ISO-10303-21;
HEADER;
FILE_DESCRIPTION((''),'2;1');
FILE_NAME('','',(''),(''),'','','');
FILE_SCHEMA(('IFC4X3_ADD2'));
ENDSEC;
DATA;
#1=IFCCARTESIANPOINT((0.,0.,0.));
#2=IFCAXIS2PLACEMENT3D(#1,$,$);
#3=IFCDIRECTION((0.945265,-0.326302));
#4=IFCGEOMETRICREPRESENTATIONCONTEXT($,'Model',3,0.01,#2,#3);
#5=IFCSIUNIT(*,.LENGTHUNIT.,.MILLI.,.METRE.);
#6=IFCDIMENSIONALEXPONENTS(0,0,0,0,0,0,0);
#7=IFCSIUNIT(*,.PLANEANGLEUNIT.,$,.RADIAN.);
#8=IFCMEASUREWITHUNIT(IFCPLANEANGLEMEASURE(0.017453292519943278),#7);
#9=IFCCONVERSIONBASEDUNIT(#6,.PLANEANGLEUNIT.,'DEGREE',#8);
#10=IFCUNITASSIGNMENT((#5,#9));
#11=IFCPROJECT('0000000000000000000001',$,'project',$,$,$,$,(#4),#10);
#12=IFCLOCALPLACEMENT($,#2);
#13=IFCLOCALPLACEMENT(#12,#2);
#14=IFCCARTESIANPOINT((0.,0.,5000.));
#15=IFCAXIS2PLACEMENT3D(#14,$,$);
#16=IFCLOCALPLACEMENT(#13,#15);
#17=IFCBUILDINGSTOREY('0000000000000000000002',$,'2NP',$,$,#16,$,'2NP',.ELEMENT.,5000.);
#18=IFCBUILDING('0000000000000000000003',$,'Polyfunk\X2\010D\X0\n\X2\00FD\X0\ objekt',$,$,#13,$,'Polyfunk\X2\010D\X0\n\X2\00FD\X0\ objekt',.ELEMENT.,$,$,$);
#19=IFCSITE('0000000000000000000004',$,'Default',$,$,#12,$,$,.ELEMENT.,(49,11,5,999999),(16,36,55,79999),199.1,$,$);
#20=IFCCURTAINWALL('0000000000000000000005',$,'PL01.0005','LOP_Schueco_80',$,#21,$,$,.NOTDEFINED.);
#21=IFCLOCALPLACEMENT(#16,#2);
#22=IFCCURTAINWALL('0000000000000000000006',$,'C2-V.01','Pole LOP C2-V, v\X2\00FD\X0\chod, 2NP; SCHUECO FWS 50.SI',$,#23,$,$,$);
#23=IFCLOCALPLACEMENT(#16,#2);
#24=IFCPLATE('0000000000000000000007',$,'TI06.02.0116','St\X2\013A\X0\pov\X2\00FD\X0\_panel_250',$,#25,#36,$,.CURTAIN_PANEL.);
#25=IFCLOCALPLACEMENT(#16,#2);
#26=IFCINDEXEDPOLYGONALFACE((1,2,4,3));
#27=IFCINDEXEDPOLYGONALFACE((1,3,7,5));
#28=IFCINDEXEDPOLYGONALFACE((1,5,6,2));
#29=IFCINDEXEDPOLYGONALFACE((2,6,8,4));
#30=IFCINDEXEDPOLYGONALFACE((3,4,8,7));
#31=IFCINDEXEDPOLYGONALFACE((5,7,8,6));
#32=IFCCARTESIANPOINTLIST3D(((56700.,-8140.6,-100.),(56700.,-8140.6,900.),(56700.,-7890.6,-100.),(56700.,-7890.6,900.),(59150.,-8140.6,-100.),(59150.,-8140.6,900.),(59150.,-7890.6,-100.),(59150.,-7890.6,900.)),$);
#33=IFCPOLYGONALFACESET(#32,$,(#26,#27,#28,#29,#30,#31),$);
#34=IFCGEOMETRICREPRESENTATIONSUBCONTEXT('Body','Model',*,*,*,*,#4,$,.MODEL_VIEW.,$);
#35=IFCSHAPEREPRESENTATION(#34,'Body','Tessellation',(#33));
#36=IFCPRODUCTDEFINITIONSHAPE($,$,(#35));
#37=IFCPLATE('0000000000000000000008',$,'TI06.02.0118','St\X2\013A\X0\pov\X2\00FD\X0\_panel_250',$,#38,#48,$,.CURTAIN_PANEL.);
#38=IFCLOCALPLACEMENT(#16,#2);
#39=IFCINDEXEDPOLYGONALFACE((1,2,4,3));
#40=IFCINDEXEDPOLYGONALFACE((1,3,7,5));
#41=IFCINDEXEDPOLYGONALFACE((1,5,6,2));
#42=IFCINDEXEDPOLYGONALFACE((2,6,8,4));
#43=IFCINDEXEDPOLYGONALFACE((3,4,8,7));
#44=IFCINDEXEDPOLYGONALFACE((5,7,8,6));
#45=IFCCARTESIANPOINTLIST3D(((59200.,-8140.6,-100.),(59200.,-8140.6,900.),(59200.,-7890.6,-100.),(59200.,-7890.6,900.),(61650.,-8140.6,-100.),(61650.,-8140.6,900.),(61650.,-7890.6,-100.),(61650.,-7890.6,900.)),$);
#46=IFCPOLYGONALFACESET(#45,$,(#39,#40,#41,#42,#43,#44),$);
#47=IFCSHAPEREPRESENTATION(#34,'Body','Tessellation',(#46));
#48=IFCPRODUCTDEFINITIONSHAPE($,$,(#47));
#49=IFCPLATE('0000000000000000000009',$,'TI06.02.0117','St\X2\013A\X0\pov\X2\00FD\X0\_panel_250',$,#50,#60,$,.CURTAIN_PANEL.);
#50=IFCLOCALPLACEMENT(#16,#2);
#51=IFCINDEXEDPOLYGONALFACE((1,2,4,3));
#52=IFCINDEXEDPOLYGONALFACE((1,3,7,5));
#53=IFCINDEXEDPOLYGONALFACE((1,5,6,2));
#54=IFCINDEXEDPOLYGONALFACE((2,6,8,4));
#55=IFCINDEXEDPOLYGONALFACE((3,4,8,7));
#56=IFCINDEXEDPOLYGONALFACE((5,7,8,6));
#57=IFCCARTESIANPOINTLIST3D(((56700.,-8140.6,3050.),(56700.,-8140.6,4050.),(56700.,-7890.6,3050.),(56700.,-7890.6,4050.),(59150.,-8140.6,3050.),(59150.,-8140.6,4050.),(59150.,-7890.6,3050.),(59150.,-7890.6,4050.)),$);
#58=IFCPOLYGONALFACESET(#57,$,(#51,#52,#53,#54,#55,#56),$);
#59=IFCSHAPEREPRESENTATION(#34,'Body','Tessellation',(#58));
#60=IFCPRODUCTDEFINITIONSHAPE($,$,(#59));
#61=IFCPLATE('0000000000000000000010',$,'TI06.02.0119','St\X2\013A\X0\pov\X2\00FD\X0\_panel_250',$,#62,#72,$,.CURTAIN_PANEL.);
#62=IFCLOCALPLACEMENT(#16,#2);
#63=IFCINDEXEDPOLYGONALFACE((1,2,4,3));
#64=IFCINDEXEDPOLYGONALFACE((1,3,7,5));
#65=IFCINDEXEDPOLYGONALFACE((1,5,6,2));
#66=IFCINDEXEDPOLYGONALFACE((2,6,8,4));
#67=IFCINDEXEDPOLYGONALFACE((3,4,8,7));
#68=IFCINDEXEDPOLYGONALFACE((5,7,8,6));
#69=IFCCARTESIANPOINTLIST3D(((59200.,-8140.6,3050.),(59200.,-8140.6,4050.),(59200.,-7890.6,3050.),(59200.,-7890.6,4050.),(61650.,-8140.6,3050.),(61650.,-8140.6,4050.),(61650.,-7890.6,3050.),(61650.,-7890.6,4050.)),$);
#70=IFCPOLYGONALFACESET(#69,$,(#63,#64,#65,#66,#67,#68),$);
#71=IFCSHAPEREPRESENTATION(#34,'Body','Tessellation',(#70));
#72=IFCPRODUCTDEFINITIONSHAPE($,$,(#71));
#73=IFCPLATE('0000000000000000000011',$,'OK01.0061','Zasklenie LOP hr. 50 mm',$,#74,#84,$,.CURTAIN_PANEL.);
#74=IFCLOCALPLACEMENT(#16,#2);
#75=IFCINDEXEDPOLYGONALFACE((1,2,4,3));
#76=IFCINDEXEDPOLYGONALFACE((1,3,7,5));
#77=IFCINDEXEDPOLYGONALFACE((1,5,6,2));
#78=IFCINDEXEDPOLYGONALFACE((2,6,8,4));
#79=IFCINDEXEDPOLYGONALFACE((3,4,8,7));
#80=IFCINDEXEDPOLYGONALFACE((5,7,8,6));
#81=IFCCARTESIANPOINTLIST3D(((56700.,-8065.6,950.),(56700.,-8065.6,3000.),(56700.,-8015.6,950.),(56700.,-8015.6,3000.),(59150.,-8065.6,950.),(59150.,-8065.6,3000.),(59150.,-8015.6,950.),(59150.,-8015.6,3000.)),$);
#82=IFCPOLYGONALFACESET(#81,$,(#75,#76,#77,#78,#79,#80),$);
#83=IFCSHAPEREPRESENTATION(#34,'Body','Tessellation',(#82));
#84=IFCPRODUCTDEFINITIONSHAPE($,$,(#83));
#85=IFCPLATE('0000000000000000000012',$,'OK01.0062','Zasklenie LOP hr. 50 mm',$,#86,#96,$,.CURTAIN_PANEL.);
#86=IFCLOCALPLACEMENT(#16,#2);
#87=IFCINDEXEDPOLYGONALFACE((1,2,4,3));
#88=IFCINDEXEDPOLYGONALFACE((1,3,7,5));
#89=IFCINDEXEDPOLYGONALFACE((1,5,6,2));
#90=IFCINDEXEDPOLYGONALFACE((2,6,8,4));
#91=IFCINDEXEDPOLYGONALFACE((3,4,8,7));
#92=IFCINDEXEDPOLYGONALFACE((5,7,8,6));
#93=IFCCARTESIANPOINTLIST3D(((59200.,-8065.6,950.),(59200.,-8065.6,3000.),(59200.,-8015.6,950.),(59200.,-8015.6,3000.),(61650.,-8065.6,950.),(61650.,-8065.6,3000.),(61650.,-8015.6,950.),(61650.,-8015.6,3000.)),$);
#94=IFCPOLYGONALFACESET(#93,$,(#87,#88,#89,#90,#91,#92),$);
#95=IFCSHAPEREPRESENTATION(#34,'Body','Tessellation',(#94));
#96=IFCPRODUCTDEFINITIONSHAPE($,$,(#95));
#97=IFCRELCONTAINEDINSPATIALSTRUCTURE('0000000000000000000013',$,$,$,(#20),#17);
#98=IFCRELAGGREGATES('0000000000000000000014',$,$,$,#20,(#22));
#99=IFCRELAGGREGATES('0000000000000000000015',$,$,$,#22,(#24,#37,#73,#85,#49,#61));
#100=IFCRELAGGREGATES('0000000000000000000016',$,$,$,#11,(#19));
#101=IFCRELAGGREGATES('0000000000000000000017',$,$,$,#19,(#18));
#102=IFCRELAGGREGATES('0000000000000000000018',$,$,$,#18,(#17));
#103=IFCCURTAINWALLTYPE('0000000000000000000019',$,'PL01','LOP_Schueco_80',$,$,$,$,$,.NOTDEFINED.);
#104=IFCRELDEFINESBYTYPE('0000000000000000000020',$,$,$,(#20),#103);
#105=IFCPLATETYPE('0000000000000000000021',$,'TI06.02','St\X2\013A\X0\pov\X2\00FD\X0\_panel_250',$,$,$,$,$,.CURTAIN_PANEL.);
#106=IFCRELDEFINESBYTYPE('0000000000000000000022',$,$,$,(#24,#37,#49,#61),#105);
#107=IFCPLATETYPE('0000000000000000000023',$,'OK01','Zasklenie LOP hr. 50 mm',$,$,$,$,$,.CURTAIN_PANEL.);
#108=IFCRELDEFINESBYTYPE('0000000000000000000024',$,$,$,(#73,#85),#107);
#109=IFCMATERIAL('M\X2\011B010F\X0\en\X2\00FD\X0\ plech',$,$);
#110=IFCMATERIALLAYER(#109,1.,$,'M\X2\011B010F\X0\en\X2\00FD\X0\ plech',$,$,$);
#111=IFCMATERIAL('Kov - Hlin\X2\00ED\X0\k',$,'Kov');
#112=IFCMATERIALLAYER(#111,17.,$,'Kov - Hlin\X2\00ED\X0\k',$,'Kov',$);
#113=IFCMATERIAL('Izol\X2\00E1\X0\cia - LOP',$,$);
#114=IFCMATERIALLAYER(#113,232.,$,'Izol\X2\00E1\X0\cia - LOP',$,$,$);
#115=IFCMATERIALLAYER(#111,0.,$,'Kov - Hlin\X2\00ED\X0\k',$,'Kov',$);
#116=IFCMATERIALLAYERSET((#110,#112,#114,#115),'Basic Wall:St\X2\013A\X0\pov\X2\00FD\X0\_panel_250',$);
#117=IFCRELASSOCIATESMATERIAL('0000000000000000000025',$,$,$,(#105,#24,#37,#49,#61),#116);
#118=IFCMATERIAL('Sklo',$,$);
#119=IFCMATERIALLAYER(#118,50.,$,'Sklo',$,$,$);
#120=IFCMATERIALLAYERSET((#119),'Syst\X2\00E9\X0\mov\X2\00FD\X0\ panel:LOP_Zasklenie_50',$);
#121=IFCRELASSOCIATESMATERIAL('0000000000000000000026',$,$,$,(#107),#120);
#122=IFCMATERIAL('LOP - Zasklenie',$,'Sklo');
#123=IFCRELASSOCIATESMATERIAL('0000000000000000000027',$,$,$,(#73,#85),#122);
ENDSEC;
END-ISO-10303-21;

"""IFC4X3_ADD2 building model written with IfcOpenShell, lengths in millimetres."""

from ifc_helpers import new_model, entity, si_unit, converted_unit, direction, frame, frame_2d, origin, origin_2d_with_axis, place, context, subcontext, project, spatial, rectangle, extrude, source, transform, mapped, material, layer, layer_set, layer_usage, type_object, type_shapes, element, aggregate, save


model = new_model("IFC4X3_ADD2")

# Units and contexts
model_context = context("Model", 3, precision=0.01, world=origin(), true_north=direction((0.945265, -0.326302)))
body_context = subcontext(model_context, "Body", "Model", "MODEL_VIEW")
ifc_project = project(units=[si_unit("LENGTHUNIT", "METRE", prefix="MILLI"), converted_unit("PLANEANGLEUNIT", "DEGREE", entity("IfcPlaneAngleMeasure", 0.017453292519943278), si_unit("PLANEANGLEUNIT", "RADIAN"), dimensions=[0, 0, 0, 0, 0, 0, 0])], contexts=[model_context])

# Site, building, storey
site_placement = place(None, origin())
site = spatial("IfcSite", under=ifc_project, at=site_placement, Name="Default", CompositionType="ELEMENT", RefLatitude=(49, 11, 5, 999999), RefLongitude=(16, 36, 55, 79999), RefElevation=199.1)
building_placement = place(site_placement, origin())
building = spatial("IfcBuilding", under=site, at=building_placement, Name="Polyfunkčný objekt", LongName="Polyfunkčný objekt", CompositionType="ELEMENT")
storey_placement = place(building_placement, frame((0.0, 0.0, 5000.0)))
storey = spatial("IfcBuildingStorey", under=building, at=storey_placement, Name="2NP", LongName="2NP", CompositionType="ELEMENT", Elevation=5000.0)

# Curtain walls, plates
curtain_wall_type = type_object("IfcCurtainWallType", Name="PL01", Description="LOP_Schueco_80", PredefinedType="NOTDEFINED")
curtain_wall_1_placement = place(storey_placement, frame((0.0, 0.0, -5000.0)))
curtain_wall_1 = element("IfcCurtainWall", 1, at=curtain_wall_1_placement, inside=storey, type_object=curtain_wall_type, Name="PL01.0005", Description="LOP_Schueco_80", PredefinedType="NOTDEFINED")
curtain_wall_2 = element("IfcCurtainWall", 2, Name="C2-V.01", Description="Pole LOP C2-V, východ, 2NP; SCHUECO FWS 50.SI")
aggregate(curtain_wall_1, [curtain_wall_2])
ifc_material_1 = material(Name="Měďený plech")
ifc_layer_1 = layer(ifc_material_1, 1.0, Name="Měďený plech")
ifc_material_2 = material(Name="Kov - Hliník", Category="Kov")
ifc_layer_2 = layer(ifc_material_2, 17.0, Name="Kov - Hliník", Category="Kov")
ifc_material_3 = material(Name="Izolácia - LOP")
ifc_layer_3 = layer(ifc_material_3, 232.0, Name="Izolácia - LOP")
ifc_layer_4 = layer(ifc_material_2, 0.0, Name="Kov - Hliník", Category="Kov")
ifc_layer_set_1 = layer_set([ifc_layer_1, ifc_layer_2, ifc_layer_3, ifc_layer_4], Name="Basic Wall:Stĺpový_panel_250")
ifc_layer_usage_1 = layer_usage(ifc_layer_set_1, "AXIS2", "POSITIVE", -125.0)
plate_type_1 = type_object("IfcPlateType", Name="TI06.02", Description="Stĺpový_panel_250", PredefinedType="CURTAIN_PANEL", material=ifc_layer_set_1)
plate_1_placement = place(storey_placement, frame((56700.0, -8015.6, -100.0)))
plate_1 = element("IfcPlate", 3, at=plate_1_placement, type_object=plate_type_1, material=ifc_layer_usage_1, Name="TI06.02.0116", Description="Stĺpový_panel_250", PredefinedType="CURTAIN_PANEL", context=body_context, shape_type="SweptSolid", body=[
    extrude(rectangle(XDim=250.0, YDim=2450.0, at=frame_2d((0.0, 0.0), x_axis=(1.0, 0.0))), frame((1225.0, 0.0, 0.0), z_axis=(0.0, 0.0, 1.0), x_axis=(0.0, 1.0, 0.0)), (0.0, 0.0, 1.0), 1000.0),
])
ifc_layer_usage_2 = layer_usage(ifc_layer_set_1, "AXIS2", "POSITIVE", -125.0)
plate_2_placement = place(storey_placement, frame((59200.0, -8015.6, -100.0)))
plate_2 = element("IfcPlate", 4, at=plate_2_placement, type_object=plate_type_1, material=ifc_layer_usage_2, Name="TI06.02.0118", Description="Stĺpový_panel_250", PredefinedType="CURTAIN_PANEL", context=body_context, shape_type="SweptSolid", body=[
    extrude(rectangle(XDim=250.0, YDim=2450.0, at=frame_2d((0.0, 0.0), x_axis=(1.0, 0.0))), frame((1225.0, 0.0, 0.0), z_axis=(0.0, 0.0, 1.0), x_axis=(0.0, 1.0, 0.0)), (0.0, 0.0, 1.0), 1000.0),
])
ifc_layer_usage_3 = layer_usage(ifc_layer_set_1, "AXIS2", "POSITIVE", -125.0)
plate_3_placement = place(storey_placement, frame((56700.0, -8015.6, 3050.0)))
plate_3 = element("IfcPlate", 5, at=plate_3_placement, type_object=plate_type_1, material=ifc_layer_usage_3, Name="TI06.02.0117", Description="Stĺpový_panel_250", PredefinedType="CURTAIN_PANEL", context=body_context, shape_type="SweptSolid", body=[
    extrude(rectangle(XDim=250.0, YDim=2450.0, at=frame_2d((0.0, 0.0), x_axis=(1.0, 0.0))), frame((1225.0, 0.0, 0.0), z_axis=(0.0, 0.0, 1.0), x_axis=(0.0, 1.0, 0.0)), (0.0, 0.0, 1.0), 1000.0),
])
ifc_layer_usage_4 = layer_usage(ifc_layer_set_1, "AXIS2", "POSITIVE", -125.0)
plate_4_placement = place(storey_placement, frame((59200.0, -8015.6, 3050.0)))
plate_4 = element("IfcPlate", 6, at=plate_4_placement, type_object=plate_type_1, material=ifc_layer_usage_4, Name="TI06.02.0119", Description="Stĺpový_panel_250", PredefinedType="CURTAIN_PANEL", context=body_context, shape_type="SweptSolid", body=[
    extrude(rectangle(XDim=250.0, YDim=2450.0, at=frame_2d((0.0, 0.0), x_axis=(1.0, 0.0))), frame((1225.0, 0.0, 0.0), z_axis=(0.0, 0.0, 1.0), x_axis=(0.0, 1.0, 0.0)), (0.0, 0.0, 1.0), 1000.0),
])
ifc_material_4 = material(Name="LOP - Zasklenie", Category="Sklo")
ifc_material_5 = material(Name="Sklo")
ifc_layer_5 = layer(ifc_material_5, 50.0, Name="Sklo")
ifc_layer_set_2 = layer_set([ifc_layer_5], Name="Systémový panel:LOP_Zasklenie_50")
plate_type_2 = type_object("IfcPlateType", Name="OK01", Description="Zasklenie LOP hr. 50 mm", PredefinedType="CURTAIN_PANEL", material=ifc_layer_set_2)
shared_shape_1 = source(origin(), body_context, "Body", "SweptSolid", [
    extrude(rectangle(XDim=50.0, YDim=2450.0, at=origin_2d_with_axis()), frame((0.0, -25.0, 0.0), z_axis=(0.0, 0.0, 1.0), x_axis=(0.0, 1.0, 0.0)), (0.0, 0.0, 1.0), 2050.0),
])
type_shapes(plate_type_2, [shared_shape_1])
plate_5_placement = place(curtain_wall_1_placement, frame((57925.0, -8015.6, 5950.0)))
plate_5 = element("IfcPlate", 7, at=plate_5_placement, type_object=plate_type_2, material=ifc_material_4, Name="OK01.0061", Description="Zasklenie LOP hr. 50 mm", PredefinedType="CURTAIN_PANEL", context=body_context, shape_type="MappedRepresentation", body=[
    mapped(shared_shape_1, transform((0.0, 0.0, 0.0), scale=1.0)),
])
plate_6_placement = place(curtain_wall_1_placement, frame((60425.0, -8015.6, 5950.0)))
plate_6 = element("IfcPlate", 8, at=plate_6_placement, type_object=plate_type_2, material=ifc_material_4, Name="OK01.0062", Description="Zasklenie LOP hr. 50 mm", PredefinedType="CURTAIN_PANEL", context=body_context, shape_type="MappedRepresentation", body=[
    mapped(shared_shape_1, transform((0.0, 0.0, 0.0), scale=1.0)),
])
aggregate(curtain_wall_2, [plate_1, plate_2, plate_5, plate_6, plate_3, plate_4])

save(model, "model.ifc")
